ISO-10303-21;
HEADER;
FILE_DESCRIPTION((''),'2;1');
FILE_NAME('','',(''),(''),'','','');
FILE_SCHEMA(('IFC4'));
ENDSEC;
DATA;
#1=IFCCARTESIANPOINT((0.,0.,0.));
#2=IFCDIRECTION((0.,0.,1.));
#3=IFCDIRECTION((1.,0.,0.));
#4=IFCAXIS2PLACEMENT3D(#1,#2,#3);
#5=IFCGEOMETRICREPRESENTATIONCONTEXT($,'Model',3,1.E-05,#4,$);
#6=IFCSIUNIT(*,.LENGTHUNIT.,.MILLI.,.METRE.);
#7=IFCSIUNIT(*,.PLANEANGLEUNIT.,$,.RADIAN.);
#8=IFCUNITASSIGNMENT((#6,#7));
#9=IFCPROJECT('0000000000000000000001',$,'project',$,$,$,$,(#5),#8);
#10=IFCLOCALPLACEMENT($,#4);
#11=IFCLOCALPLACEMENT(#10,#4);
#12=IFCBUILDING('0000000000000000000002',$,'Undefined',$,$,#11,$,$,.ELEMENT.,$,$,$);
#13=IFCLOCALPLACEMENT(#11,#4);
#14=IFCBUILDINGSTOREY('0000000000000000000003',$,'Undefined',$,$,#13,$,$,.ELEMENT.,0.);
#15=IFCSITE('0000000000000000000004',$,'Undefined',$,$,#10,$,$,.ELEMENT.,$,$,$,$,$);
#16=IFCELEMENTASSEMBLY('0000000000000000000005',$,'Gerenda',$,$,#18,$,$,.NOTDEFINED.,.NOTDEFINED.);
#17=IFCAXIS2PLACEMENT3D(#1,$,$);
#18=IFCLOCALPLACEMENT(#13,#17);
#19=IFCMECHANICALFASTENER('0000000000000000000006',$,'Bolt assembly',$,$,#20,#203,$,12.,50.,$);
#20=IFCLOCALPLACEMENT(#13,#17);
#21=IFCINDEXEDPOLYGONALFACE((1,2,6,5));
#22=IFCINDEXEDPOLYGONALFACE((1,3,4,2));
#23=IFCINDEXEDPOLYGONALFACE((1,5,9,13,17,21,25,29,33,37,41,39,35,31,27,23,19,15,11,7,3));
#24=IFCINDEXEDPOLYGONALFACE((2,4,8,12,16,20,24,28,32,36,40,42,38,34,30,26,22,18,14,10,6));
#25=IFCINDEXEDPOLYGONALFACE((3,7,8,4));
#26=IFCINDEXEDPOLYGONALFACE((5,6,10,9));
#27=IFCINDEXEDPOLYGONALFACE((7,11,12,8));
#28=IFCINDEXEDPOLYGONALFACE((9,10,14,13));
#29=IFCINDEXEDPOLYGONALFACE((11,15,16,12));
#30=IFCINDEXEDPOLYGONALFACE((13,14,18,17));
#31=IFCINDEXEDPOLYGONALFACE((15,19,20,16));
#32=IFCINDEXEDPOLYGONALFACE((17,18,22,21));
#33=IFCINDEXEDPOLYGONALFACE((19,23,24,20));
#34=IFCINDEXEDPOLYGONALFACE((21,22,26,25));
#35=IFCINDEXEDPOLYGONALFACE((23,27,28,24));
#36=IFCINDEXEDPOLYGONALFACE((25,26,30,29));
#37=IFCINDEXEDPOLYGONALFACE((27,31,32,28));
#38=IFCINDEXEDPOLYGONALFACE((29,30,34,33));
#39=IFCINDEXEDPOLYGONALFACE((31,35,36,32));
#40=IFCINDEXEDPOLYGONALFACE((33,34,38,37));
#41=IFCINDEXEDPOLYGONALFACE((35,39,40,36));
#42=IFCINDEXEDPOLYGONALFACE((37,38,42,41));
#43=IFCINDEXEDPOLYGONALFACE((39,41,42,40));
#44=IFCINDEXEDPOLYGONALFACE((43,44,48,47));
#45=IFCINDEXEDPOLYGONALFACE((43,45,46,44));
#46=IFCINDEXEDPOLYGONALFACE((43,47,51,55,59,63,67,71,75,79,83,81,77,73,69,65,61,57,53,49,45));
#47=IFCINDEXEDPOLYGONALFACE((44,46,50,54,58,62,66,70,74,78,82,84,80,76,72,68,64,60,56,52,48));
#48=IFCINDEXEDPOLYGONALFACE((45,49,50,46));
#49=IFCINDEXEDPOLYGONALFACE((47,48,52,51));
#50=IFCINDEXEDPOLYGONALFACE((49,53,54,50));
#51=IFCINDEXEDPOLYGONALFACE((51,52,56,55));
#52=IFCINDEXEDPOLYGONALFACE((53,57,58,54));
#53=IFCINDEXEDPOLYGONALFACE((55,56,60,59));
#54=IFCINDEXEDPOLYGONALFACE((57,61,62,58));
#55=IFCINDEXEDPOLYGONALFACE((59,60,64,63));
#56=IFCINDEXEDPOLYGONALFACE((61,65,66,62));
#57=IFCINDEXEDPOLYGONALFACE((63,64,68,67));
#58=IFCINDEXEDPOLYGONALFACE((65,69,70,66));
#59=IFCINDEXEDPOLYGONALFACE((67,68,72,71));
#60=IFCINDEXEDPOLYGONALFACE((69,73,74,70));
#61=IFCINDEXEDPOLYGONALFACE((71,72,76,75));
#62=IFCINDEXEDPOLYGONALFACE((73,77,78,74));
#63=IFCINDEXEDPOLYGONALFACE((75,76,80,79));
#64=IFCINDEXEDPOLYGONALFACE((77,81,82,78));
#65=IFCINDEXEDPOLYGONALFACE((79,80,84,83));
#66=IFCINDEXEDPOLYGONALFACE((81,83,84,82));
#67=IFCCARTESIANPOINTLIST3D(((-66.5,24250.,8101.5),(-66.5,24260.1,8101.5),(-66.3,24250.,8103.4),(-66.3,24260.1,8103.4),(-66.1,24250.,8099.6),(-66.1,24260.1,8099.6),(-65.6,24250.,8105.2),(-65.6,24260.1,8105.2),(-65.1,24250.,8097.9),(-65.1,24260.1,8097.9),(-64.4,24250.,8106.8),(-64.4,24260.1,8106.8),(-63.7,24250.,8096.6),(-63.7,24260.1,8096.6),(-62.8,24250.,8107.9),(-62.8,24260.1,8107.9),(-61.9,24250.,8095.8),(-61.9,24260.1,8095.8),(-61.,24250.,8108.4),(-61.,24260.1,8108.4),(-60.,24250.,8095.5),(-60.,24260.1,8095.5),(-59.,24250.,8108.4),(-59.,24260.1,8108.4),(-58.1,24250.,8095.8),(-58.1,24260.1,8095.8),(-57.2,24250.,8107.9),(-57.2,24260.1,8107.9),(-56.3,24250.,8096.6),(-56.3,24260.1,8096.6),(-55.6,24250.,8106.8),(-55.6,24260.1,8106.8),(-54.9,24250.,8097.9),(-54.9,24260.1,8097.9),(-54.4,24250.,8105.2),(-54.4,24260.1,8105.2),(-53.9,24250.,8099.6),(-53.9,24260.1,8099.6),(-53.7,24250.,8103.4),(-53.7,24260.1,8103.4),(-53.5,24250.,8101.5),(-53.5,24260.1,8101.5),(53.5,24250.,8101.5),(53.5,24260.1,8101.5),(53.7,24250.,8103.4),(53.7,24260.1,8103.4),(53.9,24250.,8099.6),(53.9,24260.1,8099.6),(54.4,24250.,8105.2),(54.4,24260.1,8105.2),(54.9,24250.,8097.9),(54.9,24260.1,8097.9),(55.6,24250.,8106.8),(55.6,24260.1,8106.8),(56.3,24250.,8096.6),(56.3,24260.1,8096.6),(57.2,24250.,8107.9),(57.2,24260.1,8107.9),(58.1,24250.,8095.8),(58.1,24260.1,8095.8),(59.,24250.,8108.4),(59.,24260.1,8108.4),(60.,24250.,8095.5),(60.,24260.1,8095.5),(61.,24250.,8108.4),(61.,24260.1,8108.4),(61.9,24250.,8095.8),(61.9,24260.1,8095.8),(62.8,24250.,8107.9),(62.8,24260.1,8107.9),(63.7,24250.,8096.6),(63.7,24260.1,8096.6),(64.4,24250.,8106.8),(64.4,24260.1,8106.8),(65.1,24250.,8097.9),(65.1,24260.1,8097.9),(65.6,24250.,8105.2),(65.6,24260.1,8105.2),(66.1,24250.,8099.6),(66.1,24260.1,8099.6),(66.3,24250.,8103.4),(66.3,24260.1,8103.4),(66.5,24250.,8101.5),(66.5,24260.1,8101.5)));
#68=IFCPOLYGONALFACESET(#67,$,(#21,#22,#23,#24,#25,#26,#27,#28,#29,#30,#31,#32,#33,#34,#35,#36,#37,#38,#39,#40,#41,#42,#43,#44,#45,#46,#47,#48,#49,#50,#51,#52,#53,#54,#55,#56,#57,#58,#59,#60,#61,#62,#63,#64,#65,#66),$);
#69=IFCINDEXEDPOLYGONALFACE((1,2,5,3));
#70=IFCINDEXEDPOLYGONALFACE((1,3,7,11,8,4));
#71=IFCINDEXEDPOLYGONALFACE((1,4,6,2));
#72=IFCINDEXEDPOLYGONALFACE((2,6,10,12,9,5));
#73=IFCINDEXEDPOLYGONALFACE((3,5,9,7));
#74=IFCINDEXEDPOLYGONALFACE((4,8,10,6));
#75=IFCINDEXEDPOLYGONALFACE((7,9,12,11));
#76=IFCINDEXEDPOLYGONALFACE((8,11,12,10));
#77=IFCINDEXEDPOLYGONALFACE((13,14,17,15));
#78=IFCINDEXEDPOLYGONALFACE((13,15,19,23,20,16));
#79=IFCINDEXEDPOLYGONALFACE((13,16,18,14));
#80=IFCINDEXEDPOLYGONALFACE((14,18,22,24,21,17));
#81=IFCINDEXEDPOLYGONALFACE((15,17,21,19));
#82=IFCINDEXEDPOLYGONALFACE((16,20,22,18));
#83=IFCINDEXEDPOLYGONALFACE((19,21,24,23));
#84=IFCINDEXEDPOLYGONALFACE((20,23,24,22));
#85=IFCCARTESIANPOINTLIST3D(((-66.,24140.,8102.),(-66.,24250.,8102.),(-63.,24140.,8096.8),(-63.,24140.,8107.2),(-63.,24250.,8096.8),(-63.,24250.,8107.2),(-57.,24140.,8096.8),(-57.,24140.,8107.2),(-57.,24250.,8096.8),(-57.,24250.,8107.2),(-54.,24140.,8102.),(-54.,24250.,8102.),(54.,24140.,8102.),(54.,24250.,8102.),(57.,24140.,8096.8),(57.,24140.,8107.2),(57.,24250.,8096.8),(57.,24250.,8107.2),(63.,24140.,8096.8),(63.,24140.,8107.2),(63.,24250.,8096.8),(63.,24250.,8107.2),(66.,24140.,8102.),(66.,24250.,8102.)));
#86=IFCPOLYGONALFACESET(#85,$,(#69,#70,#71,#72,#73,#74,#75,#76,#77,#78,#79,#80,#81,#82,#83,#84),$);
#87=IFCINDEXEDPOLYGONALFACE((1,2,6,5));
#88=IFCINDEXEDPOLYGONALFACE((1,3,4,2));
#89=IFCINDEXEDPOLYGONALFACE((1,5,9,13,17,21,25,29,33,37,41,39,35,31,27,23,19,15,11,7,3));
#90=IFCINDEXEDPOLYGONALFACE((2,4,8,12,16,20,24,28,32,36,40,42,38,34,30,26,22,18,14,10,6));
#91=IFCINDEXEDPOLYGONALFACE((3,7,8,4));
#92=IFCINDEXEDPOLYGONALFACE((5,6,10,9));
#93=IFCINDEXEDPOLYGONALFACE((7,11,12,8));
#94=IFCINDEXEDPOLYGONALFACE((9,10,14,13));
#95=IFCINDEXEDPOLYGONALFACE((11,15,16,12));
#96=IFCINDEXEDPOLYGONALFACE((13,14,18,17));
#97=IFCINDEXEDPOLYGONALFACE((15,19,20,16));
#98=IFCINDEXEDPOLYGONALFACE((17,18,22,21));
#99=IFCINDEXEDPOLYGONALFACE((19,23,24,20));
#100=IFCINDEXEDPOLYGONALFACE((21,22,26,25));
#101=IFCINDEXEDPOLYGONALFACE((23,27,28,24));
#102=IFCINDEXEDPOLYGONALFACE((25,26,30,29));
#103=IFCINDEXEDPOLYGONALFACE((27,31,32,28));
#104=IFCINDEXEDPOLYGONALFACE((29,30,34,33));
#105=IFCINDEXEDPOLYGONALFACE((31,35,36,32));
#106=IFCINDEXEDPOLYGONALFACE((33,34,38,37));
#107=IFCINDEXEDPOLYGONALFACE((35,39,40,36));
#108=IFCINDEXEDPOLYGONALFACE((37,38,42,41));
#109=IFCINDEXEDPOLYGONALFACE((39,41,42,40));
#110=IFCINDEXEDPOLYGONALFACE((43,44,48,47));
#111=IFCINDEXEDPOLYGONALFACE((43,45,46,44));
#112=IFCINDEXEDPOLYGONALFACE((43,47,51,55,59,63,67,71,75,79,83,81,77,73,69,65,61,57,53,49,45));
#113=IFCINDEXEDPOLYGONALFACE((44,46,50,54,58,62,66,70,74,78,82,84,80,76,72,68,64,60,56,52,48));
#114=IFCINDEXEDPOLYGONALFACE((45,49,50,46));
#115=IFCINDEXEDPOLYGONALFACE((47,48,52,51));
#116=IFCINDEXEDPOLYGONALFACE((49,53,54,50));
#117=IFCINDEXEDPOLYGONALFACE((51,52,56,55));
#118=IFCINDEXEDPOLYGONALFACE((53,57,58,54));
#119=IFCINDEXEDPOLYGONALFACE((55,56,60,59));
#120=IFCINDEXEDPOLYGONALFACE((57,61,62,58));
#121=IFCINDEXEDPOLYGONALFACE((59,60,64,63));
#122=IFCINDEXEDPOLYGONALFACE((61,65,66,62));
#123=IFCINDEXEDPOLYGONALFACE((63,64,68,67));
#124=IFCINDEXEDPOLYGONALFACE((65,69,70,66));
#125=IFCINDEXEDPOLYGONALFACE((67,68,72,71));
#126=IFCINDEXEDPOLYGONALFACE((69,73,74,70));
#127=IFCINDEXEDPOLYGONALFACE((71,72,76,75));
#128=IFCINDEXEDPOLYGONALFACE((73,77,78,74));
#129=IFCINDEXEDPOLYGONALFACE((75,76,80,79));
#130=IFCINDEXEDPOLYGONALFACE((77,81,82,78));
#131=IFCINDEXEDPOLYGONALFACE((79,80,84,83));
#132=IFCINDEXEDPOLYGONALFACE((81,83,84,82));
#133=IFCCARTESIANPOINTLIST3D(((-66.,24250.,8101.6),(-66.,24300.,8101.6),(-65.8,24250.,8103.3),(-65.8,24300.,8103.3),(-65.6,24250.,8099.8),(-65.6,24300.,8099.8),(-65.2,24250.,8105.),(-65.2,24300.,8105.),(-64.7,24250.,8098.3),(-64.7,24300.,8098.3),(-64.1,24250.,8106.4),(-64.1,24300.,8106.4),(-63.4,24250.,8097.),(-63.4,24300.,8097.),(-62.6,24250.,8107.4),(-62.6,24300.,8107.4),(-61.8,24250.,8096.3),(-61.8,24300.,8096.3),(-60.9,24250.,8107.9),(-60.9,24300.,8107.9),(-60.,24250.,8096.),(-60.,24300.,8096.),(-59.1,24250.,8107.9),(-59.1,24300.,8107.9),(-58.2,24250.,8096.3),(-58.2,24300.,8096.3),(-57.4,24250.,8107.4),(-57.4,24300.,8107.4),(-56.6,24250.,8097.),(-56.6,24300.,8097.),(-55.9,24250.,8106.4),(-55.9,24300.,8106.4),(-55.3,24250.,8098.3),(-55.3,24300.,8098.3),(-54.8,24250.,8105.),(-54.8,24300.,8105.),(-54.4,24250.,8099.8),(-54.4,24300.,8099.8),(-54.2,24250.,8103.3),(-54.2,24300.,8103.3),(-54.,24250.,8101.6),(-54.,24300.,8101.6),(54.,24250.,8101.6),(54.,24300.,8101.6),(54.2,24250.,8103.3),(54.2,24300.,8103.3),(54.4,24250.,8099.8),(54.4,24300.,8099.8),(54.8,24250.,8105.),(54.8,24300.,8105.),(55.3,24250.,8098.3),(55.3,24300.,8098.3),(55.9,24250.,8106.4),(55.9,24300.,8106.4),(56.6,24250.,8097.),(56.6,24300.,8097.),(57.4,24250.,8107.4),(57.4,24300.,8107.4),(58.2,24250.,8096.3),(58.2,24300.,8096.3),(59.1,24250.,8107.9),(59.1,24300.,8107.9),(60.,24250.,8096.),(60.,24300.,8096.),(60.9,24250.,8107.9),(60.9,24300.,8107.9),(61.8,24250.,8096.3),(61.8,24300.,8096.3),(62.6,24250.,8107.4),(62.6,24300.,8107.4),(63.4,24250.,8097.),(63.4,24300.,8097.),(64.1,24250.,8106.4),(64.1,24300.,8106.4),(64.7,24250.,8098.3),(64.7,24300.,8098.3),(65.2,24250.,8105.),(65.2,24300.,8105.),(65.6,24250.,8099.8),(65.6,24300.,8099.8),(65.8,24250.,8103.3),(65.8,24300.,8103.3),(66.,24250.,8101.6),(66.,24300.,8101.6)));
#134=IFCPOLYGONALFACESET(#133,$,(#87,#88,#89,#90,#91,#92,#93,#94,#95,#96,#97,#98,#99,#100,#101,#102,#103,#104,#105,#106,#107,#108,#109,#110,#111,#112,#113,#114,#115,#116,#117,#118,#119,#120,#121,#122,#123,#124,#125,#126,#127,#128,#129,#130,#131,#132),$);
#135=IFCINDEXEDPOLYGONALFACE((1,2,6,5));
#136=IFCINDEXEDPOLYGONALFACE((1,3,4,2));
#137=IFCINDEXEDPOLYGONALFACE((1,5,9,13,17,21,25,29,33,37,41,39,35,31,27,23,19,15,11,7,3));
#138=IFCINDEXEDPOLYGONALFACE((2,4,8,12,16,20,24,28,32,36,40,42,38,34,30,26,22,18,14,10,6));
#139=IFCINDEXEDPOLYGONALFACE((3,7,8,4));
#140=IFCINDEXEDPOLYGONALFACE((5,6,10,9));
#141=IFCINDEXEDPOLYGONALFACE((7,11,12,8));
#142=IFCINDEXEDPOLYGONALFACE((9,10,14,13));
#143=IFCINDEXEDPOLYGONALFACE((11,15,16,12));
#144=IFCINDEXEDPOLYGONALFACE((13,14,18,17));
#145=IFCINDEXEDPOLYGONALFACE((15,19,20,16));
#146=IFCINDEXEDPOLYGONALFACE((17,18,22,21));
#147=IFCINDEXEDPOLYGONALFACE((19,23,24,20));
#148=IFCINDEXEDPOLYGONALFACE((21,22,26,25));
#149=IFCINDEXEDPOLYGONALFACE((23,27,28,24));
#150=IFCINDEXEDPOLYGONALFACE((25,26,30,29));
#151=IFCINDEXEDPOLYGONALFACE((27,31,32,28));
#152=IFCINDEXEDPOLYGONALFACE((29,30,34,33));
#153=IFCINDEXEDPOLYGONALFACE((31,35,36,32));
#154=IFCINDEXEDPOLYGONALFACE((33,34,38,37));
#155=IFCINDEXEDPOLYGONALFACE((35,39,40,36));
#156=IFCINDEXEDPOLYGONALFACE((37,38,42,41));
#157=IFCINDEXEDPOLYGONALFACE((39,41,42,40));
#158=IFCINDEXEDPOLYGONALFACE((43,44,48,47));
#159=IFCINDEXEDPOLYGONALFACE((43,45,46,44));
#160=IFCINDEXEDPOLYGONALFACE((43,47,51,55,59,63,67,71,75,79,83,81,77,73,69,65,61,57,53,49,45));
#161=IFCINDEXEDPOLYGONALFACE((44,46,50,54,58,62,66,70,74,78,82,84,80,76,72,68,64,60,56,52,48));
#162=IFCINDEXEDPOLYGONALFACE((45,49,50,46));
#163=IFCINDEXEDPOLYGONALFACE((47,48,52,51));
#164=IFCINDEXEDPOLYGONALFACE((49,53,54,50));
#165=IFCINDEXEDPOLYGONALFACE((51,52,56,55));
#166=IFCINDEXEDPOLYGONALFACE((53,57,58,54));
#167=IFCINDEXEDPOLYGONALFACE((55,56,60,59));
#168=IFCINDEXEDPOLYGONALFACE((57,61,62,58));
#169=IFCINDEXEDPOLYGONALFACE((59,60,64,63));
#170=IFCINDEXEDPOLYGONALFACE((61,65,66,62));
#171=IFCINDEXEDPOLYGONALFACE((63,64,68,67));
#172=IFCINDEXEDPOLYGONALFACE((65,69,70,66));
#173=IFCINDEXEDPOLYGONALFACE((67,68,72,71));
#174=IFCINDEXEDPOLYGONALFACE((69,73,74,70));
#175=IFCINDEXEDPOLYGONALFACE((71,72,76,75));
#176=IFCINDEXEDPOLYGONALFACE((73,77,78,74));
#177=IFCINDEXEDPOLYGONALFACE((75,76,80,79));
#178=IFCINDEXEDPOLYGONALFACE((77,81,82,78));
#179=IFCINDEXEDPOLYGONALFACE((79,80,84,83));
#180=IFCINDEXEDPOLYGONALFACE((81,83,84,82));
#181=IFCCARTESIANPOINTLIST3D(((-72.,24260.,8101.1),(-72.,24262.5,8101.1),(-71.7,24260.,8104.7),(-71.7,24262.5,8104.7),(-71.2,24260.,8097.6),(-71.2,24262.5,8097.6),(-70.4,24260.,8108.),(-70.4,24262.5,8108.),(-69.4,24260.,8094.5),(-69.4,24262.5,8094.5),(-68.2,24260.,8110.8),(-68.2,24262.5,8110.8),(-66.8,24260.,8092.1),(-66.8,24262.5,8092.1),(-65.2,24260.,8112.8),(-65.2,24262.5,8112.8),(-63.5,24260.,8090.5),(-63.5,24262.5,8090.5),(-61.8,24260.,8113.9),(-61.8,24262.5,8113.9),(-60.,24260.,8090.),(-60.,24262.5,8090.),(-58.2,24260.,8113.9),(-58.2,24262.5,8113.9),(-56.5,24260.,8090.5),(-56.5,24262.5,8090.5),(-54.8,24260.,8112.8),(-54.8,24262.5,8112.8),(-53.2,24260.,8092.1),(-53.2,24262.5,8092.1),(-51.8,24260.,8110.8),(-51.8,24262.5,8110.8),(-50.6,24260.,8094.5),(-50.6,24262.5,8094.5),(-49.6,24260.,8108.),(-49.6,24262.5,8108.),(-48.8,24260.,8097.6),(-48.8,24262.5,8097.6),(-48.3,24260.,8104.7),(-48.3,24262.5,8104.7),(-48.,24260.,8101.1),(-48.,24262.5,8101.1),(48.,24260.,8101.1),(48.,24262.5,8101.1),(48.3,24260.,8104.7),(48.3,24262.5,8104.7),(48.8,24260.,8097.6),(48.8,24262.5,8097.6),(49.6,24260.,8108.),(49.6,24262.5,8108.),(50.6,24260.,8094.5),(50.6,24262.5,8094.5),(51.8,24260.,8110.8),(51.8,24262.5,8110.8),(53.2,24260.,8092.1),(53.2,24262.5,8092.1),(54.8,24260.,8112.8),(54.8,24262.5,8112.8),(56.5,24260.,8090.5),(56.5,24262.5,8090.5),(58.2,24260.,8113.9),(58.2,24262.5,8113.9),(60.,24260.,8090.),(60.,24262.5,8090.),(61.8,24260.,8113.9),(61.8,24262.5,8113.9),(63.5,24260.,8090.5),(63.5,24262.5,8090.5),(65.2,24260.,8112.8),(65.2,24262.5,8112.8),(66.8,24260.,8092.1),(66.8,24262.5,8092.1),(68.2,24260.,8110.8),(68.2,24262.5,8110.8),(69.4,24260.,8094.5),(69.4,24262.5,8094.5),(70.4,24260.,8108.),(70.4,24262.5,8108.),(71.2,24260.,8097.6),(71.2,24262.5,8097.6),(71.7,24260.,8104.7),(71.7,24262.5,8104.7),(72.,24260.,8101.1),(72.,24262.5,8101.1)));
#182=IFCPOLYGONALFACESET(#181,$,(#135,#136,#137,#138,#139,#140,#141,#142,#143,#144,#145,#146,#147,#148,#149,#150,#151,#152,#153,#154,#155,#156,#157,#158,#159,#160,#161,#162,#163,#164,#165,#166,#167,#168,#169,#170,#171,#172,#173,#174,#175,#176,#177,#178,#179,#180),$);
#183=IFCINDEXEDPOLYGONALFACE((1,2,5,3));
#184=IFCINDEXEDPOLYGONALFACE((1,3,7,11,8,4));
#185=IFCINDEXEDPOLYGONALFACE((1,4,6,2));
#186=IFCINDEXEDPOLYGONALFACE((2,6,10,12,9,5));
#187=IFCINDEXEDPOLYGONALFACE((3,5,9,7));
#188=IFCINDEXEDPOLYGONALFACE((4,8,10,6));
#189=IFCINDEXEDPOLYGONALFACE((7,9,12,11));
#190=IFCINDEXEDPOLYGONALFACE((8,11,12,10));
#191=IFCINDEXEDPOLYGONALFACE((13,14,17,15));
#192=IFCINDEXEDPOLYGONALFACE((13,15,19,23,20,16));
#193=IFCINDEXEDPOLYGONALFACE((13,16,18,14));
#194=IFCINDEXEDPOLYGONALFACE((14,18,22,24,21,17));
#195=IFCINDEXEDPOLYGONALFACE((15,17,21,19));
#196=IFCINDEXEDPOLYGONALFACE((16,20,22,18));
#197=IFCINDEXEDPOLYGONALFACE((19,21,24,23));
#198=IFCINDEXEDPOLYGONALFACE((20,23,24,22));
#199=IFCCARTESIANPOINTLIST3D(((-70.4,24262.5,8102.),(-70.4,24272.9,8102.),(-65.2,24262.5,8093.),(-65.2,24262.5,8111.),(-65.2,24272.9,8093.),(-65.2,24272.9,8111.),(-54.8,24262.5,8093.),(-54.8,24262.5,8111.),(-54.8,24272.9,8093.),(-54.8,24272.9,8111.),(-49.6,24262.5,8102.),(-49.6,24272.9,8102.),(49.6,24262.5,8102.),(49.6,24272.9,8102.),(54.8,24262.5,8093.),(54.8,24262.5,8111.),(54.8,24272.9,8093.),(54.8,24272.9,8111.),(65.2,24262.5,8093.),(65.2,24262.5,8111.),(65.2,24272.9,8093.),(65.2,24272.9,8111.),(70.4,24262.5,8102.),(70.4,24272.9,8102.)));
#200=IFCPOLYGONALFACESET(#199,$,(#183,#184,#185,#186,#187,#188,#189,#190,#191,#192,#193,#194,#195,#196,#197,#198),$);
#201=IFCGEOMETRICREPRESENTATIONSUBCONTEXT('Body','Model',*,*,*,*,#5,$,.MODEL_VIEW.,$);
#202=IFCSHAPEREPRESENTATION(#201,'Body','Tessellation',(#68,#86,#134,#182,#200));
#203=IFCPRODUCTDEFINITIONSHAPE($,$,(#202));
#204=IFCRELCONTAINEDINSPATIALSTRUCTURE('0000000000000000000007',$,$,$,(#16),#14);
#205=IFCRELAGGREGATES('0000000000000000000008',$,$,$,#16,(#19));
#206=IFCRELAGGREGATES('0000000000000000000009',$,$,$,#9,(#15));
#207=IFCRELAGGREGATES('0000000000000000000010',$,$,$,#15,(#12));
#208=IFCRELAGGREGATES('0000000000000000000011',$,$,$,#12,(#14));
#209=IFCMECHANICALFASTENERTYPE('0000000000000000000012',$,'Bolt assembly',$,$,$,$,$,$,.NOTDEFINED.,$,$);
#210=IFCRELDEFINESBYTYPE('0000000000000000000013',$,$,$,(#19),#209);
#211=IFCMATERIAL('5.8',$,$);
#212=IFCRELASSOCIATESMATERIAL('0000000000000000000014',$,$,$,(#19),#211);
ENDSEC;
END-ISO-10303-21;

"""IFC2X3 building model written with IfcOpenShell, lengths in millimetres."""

from ifc_helpers import new_model, si_unit, frame, origin_with_axes, origin_2d_with_axis, place, context, subcontext, project, spatial, polyline, circle, outline, extrude, source, transform, mapped, material, type_object, element, aggregate, save


model = new_model("IFC2X3")

# Units and contexts
model_context = context("Model", 3, precision=1e-05, world=origin_with_axes())
body_context = subcontext(model_context, "Body", "Model", "MODEL_VIEW")
ifc_project = project(units=[si_unit("LENGTHUNIT", "METRE", prefix="MILLI"), si_unit("PLANEANGLEUNIT", "RADIAN")], contexts=[model_context])

# Site, building, storey
site_placement = place(None, origin_with_axes())
site = spatial("IfcSite", under=ifc_project, at=site_placement, Name="Undefined", CompositionType="ELEMENT")
building_placement = place(site_placement, origin_with_axes())
building = spatial("IfcBuilding", under=site, at=building_placement, Name="Undefined", CompositionType="ELEMENT")
storey_placement = place(building_placement, origin_with_axes())
storey = spatial("IfcBuildingStorey", under=building, at=storey_placement, Name="Undefined", CompositionType="ELEMENT", Elevation=0.0)

# Element assembly
assembly_1_placement = place(storey_placement, origin_with_axes())
assembly_1 = element("IfcElementAssembly", 1, at=assembly_1_placement, inside=storey, Name="Gerenda", AssemblyPlace="NOTDEFINED", PredefinedType="NOTDEFINED")

# Mechanical fastener
mechanical_fastener_type = type_object("IfcMechanicalFastenerType", Name="Bolt assembly")
ifc_material_1 = material(Name="5.8")
shared_shape_1 = source(origin_with_axes(), body_context, "Body", "SweptSolid", [
    extrude(circle(Radius=6.5, at=origin_2d_with_axis()), frame((0.0, -10.0, 0.0), z_axis=(0.0, 1.0, 0.0), x_axis=(1.0, 0.0, 0.0)), (0.0, 0.0, 1.0), 10.1),
    extrude(outline(polyline([(5.2, -3.0), (5.2, 3.0), (0.0, 6.0), (-5.2, 3.0), (-5.2, -3.0), (0.0, -6.0), (5.2, -3.0)])), frame((0.0, -120.0, 0.0), z_axis=(0.0, 1.0, 0.0), x_axis=(1.0, 0.0, 0.0)), (0.0, 0.0, 1.0), 110.0),
    extrude(circle(Radius=6.0, at=origin_2d_with_axis()), frame((0.0, -10.0, 0.0), z_axis=(0.0, 1.0, 0.0), x_axis=(1.0, 0.0, 0.0)), (0.0, 0.0, 1.0), 50.0),
    extrude(circle(Radius=12.0, at=origin_2d_with_axis()), frame((0.0, 0.0, 0.0), z_axis=(0.0, 1.0, 0.0), x_axis=(1.0, 0.0, 0.0)), (0.0, 0.0, 1.0), 2.5),
    extrude(outline(polyline([(9.0, -5.2), (9.0, 5.2), (0.0, 10.4), (-9.0, 5.2), (-9.0, -5.2), (0.0, -10.4), (9.0, -5.2)])), frame((0.0, 2.5, 0.0), z_axis=(0.0, 1.0, 0.0), x_axis=(1.0, 0.0, 0.0)), (0.0, 0.0, 1.0), 10.4),
])
mechanical_fastener_1_placement = place(assembly_1_placement, frame((0.0, 24260.0, 8150.0), z_axis=(1.0, -0.000003, 0.0), x_axis=(0.0, 0.0, -1.0)))
mechanical_fastener_1 = element("IfcMechanicalFastener", 2, at=mechanical_fastener_1_placement, type_object=mechanical_fastener_type, material=ifc_material_1, Name="Bolt assembly", NominalDiameter=12.0, NominalLength=50.0, context=body_context, shape_type="MappedRepresentation", body=[
    mapped(shared_shape_1, transform((48.0, 0.0, -60.0))),
    mapped(shared_shape_1, transform((48.0, 0.0, 60.0))),
])
aggregate(assembly_1, [mechanical_fastener_1])

save(model, "model.ifc")
